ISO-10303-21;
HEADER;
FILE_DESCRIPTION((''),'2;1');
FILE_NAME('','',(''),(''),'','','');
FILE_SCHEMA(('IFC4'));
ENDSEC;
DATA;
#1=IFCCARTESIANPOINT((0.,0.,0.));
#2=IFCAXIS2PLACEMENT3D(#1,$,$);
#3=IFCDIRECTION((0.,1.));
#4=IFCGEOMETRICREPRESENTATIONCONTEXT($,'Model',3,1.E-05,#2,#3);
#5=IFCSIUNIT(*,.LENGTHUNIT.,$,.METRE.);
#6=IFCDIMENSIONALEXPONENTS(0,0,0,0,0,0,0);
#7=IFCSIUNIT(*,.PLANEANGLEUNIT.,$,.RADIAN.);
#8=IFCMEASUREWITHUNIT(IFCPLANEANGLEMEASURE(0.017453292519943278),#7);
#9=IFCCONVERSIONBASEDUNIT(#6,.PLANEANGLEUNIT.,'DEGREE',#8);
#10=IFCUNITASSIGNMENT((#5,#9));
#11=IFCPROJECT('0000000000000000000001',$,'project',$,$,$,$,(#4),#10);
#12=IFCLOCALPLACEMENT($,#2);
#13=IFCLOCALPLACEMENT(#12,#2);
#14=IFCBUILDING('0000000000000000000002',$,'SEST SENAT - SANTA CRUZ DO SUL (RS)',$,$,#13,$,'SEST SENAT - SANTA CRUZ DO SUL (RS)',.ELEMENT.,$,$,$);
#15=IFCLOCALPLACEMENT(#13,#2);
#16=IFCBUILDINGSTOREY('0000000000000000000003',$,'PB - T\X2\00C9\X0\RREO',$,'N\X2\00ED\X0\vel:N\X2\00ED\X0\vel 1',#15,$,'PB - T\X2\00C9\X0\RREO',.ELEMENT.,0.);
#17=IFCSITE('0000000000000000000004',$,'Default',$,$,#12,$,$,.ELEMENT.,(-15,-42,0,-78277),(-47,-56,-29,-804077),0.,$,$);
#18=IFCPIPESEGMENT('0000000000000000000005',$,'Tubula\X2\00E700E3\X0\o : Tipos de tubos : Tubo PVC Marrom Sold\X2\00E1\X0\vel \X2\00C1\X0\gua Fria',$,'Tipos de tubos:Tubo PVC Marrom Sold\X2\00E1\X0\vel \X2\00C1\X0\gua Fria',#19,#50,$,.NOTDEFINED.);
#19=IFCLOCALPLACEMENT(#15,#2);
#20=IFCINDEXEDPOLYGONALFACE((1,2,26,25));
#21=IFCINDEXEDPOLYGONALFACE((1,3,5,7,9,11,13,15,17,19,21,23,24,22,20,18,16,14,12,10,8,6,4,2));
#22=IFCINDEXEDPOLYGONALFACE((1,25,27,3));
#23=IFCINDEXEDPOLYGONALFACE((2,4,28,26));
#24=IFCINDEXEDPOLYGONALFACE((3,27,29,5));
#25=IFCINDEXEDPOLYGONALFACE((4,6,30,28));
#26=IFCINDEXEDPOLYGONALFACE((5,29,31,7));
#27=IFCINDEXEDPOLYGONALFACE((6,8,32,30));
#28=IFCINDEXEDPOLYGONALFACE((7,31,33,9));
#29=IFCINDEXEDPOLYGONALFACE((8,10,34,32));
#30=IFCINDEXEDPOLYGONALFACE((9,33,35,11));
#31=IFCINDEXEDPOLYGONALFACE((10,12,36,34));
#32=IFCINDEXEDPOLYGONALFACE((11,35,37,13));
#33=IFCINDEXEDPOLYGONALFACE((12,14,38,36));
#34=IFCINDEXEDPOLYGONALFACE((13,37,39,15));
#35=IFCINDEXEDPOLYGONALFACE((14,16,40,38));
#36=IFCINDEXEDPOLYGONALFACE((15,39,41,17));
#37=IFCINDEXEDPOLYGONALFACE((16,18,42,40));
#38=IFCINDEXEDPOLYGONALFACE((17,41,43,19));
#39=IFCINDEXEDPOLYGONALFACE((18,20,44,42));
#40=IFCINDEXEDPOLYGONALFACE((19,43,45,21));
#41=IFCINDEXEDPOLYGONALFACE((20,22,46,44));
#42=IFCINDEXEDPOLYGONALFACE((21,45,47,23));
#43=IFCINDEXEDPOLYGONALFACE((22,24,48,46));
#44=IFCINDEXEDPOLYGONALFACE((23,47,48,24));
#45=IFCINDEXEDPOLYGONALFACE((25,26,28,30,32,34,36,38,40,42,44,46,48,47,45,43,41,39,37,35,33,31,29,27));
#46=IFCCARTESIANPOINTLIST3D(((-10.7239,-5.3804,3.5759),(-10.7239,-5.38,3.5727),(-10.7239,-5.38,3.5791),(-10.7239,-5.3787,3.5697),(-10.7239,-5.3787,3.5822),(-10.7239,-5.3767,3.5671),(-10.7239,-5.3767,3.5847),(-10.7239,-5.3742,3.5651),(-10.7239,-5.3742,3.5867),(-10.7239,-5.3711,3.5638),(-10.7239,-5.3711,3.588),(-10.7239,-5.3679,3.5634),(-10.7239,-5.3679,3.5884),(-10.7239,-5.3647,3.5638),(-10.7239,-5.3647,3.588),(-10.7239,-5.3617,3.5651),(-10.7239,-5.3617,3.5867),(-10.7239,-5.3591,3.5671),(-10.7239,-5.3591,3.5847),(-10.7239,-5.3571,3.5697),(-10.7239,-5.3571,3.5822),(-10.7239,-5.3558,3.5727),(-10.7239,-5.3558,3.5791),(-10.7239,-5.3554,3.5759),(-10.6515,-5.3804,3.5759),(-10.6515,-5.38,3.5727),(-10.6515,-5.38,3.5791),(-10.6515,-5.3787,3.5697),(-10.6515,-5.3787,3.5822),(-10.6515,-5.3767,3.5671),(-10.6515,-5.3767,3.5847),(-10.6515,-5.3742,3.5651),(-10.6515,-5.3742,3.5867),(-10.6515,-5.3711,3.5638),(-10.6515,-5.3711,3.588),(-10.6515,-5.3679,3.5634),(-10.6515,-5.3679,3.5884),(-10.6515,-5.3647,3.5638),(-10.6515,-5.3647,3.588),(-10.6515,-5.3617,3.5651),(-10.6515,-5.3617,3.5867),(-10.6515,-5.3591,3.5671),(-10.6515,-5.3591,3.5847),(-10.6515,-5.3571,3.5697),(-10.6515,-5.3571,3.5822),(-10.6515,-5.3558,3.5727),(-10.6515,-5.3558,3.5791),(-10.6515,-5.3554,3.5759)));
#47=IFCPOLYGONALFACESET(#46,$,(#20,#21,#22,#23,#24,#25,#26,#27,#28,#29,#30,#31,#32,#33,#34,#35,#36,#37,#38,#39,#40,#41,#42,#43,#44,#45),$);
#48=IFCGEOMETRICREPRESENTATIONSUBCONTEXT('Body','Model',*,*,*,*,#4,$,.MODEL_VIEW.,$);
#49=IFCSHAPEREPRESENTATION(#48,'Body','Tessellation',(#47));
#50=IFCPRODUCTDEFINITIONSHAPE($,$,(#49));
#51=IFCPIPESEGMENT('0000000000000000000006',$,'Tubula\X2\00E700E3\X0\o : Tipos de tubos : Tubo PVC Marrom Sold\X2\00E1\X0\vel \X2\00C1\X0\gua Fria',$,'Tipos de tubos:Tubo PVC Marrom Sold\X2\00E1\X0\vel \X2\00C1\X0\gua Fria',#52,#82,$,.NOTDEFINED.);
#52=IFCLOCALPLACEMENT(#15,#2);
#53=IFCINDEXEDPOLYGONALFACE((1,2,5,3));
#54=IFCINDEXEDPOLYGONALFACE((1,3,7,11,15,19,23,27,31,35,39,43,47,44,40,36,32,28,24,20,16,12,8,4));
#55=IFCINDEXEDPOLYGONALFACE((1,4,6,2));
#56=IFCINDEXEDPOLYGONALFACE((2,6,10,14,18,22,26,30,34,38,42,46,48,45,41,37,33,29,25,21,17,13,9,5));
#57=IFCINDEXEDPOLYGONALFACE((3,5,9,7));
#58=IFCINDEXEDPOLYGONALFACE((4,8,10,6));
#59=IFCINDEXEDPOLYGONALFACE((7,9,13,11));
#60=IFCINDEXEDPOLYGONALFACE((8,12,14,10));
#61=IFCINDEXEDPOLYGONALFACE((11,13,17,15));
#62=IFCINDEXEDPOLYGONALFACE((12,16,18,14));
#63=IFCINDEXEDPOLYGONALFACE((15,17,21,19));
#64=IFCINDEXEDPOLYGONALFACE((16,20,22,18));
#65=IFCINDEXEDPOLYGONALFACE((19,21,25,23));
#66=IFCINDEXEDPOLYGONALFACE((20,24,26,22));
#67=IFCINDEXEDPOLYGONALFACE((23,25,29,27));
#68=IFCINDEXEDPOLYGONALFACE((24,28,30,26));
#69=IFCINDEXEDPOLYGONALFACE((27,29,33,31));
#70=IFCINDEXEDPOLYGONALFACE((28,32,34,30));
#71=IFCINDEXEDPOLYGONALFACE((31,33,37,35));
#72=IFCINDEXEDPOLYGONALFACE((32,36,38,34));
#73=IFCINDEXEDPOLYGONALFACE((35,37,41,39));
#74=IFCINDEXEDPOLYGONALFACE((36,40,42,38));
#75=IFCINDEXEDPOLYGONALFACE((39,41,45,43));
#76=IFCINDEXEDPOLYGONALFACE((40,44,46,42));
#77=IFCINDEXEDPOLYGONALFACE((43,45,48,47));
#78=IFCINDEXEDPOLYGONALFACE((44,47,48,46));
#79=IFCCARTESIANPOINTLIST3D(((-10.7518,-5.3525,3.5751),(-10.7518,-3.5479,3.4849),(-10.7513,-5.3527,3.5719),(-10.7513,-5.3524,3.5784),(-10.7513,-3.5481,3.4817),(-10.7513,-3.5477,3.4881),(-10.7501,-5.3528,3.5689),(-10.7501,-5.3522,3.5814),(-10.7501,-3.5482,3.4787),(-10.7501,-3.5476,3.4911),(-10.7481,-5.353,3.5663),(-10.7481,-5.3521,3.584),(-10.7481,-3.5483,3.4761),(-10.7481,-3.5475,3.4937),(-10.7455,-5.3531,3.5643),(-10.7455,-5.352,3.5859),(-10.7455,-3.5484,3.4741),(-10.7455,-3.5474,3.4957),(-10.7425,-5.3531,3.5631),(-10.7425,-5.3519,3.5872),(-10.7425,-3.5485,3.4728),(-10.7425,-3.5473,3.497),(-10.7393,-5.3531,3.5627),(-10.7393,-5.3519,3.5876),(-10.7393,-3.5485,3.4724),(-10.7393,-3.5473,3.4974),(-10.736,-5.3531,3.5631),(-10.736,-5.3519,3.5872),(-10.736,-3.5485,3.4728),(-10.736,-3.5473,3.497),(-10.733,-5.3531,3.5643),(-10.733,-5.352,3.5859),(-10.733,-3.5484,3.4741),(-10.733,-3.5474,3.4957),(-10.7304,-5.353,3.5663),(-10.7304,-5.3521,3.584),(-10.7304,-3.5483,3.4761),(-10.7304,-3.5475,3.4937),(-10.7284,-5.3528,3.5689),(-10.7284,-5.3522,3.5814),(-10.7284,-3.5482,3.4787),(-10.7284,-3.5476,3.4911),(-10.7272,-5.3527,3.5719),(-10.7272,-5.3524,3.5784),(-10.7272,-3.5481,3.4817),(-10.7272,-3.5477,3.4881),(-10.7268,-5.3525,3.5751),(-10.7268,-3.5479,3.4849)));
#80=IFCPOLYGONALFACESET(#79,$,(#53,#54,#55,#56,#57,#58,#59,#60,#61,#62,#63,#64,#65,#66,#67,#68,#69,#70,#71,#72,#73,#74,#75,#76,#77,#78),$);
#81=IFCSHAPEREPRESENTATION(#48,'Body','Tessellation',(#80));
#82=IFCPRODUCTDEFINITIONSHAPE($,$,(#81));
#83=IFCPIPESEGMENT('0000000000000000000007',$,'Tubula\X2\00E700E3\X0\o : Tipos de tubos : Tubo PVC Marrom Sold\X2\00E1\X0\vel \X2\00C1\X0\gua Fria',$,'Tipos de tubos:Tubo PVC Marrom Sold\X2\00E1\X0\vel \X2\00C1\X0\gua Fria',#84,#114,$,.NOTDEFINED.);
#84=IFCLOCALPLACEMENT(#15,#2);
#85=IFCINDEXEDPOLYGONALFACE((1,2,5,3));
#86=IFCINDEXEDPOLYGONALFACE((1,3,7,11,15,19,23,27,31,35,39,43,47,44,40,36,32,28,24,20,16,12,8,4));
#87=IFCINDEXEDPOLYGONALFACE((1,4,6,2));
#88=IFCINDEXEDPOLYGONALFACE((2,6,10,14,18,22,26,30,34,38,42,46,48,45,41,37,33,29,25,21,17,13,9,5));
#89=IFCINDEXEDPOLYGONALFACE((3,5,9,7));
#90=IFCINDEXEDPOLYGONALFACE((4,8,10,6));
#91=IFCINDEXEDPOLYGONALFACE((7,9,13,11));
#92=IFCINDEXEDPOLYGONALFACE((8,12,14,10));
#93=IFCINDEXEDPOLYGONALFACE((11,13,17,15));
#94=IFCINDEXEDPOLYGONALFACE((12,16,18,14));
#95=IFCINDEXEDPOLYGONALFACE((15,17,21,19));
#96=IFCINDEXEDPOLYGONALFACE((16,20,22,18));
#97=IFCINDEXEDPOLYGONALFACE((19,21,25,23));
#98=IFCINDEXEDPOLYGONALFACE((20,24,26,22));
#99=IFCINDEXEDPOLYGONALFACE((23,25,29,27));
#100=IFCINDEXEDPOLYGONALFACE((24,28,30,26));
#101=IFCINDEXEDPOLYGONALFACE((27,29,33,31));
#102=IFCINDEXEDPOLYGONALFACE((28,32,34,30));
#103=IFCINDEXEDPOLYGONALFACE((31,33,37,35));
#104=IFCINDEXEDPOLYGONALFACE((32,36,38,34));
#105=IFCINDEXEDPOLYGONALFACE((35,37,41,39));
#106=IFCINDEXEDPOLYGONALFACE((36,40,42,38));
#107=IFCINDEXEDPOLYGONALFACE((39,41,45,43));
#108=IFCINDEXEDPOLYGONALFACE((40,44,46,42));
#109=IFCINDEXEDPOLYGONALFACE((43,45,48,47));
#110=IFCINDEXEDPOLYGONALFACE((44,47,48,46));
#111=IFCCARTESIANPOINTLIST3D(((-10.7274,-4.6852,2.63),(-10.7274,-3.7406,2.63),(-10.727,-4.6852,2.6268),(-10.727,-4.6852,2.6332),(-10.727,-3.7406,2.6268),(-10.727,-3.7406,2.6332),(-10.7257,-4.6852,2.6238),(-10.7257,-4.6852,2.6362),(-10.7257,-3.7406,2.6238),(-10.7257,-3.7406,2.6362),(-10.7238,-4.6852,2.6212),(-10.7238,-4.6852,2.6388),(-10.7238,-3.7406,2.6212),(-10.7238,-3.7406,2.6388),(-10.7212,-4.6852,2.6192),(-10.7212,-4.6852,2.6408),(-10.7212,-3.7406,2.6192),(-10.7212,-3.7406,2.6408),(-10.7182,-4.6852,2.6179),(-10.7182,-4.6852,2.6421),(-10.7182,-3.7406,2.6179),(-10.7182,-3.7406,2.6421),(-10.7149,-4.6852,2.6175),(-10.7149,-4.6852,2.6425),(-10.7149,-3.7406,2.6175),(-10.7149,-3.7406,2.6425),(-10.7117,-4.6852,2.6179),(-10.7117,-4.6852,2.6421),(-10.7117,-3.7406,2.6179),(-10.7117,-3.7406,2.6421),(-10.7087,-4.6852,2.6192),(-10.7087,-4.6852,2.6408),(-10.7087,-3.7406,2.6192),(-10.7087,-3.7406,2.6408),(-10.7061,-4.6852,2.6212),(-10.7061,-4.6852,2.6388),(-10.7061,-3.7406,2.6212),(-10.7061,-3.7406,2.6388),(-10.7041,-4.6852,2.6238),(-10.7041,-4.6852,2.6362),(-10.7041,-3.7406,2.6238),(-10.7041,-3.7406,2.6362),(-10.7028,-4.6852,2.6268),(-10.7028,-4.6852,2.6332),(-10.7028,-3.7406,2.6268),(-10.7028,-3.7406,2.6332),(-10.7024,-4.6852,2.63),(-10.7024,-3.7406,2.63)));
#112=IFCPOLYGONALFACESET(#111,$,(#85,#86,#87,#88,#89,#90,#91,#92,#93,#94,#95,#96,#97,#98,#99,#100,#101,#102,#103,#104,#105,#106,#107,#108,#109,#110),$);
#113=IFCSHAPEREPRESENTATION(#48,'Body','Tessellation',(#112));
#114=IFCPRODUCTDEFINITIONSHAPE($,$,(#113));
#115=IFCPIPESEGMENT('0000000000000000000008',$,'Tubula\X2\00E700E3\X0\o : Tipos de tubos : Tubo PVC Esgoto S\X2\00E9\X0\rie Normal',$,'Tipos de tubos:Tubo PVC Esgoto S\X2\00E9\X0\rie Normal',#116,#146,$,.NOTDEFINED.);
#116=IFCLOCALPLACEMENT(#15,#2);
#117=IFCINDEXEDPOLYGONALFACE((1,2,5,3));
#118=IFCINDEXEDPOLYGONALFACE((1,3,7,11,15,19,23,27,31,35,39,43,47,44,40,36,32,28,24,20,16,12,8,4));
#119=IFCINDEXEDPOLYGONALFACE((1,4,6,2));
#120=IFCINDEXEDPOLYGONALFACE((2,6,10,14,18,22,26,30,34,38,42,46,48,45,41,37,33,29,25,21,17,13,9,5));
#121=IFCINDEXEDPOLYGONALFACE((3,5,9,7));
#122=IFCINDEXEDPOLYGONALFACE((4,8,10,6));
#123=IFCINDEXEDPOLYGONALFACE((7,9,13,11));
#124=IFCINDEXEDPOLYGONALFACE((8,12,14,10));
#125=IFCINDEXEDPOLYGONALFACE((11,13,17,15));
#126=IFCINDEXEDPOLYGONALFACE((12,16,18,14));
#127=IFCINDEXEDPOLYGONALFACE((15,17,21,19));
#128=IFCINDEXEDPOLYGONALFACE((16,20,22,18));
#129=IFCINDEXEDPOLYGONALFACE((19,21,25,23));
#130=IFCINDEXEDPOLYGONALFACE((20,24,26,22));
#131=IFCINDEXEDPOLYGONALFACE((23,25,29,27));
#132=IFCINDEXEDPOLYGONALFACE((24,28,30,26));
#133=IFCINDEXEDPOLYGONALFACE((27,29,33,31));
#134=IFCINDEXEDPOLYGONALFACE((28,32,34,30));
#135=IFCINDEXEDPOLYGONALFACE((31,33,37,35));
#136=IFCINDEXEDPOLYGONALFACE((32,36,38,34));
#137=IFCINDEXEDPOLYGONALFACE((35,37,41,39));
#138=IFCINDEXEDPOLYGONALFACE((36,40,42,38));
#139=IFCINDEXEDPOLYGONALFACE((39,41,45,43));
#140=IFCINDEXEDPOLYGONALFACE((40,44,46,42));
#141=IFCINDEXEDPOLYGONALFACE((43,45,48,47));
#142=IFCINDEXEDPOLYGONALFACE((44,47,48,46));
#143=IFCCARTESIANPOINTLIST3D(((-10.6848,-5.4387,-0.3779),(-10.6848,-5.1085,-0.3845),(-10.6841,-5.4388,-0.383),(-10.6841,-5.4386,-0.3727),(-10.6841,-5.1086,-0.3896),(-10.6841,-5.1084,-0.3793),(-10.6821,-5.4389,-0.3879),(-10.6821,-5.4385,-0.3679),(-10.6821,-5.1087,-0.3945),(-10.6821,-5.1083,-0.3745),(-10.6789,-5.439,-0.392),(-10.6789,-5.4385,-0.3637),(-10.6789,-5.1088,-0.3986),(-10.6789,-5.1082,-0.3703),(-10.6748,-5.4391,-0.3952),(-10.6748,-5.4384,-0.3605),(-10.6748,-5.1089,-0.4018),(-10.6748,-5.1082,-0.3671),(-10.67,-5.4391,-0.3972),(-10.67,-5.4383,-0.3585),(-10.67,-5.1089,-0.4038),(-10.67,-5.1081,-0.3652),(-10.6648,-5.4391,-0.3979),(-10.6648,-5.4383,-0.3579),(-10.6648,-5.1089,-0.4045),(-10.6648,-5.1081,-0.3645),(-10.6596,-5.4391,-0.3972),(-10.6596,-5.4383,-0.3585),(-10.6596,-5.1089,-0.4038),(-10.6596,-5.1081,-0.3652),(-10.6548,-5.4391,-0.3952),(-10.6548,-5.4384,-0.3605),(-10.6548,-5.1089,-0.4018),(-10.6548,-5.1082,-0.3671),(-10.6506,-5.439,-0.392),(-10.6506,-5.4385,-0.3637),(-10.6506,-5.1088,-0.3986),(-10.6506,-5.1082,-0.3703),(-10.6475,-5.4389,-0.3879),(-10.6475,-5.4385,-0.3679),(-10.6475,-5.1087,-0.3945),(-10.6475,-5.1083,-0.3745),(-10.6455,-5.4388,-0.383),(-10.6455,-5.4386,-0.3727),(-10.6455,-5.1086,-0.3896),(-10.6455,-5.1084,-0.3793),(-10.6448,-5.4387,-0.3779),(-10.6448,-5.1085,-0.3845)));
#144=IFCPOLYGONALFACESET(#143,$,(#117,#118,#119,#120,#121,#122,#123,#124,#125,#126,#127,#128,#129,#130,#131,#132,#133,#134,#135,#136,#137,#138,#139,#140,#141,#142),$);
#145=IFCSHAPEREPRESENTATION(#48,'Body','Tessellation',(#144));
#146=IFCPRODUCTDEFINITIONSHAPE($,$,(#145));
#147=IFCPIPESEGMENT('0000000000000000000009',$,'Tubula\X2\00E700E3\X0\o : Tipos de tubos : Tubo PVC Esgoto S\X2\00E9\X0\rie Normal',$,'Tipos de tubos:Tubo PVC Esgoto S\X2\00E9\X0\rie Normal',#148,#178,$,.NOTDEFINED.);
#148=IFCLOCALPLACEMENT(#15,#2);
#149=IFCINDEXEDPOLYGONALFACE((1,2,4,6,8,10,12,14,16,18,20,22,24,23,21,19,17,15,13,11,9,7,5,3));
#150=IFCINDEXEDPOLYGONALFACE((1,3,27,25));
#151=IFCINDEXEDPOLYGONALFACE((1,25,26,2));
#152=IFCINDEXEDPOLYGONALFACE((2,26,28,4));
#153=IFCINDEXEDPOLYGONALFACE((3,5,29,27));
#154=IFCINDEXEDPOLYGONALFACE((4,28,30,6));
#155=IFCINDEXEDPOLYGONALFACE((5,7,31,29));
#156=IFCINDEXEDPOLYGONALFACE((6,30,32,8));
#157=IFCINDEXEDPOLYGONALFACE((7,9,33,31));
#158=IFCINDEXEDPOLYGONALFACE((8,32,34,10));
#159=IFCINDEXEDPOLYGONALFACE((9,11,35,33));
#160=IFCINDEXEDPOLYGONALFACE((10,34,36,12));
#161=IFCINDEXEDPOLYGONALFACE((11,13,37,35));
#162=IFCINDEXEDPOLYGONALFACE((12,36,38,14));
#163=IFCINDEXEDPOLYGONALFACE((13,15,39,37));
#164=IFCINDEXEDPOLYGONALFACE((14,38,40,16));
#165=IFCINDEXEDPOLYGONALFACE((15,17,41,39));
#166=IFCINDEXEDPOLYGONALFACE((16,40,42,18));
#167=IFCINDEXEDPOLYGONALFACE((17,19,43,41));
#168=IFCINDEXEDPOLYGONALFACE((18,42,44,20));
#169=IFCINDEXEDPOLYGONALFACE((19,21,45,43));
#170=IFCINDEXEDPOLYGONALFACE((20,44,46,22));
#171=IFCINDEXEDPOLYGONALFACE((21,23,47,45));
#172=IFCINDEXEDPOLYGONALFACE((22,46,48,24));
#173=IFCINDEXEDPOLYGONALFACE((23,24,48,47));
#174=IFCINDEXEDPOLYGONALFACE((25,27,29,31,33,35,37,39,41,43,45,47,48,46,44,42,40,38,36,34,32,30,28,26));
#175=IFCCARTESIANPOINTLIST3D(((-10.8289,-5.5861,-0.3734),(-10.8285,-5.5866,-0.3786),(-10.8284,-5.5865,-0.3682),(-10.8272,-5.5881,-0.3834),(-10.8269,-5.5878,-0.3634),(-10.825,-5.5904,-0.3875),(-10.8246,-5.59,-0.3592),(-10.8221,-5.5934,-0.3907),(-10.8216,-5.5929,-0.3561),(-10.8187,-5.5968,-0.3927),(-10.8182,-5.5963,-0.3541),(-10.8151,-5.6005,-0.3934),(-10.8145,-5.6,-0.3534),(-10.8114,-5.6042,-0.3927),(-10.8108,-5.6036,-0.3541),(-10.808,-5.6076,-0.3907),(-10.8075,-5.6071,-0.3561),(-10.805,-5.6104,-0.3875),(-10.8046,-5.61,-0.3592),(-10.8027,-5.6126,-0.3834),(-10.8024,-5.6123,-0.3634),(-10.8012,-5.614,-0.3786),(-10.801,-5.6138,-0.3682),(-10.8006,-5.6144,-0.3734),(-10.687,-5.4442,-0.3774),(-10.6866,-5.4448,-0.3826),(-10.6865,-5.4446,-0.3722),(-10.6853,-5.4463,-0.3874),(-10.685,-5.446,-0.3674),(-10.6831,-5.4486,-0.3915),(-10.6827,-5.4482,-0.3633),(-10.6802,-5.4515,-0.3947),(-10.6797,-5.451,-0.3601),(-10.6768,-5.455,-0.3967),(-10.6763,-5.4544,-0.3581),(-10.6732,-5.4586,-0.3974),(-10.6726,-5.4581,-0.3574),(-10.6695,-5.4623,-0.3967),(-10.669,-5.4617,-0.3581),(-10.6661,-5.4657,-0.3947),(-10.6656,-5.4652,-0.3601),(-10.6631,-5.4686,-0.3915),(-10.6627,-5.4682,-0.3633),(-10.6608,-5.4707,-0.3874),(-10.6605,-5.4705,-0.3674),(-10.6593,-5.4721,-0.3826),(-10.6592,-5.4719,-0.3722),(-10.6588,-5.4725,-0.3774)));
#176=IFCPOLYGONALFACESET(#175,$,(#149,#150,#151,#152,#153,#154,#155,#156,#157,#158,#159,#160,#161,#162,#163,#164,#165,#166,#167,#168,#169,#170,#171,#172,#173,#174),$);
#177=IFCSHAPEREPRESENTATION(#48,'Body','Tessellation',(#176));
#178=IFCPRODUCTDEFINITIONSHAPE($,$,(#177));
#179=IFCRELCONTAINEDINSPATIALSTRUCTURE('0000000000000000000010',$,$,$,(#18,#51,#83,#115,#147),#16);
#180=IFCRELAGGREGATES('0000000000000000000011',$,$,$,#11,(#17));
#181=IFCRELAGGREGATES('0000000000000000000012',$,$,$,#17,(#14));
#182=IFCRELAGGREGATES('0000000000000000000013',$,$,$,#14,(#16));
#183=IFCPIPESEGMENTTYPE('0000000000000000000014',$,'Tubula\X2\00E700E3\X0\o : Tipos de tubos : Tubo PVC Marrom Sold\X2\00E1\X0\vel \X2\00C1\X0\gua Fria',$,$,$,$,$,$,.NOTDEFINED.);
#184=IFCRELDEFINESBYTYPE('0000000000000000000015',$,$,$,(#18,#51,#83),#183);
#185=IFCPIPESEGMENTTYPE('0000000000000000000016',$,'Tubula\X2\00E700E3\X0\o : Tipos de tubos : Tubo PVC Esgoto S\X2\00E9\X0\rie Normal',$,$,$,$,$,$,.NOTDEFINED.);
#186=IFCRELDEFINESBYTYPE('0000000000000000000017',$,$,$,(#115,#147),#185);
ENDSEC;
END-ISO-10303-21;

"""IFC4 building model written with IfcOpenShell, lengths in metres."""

from ifc_helpers import new_model, entity, si_unit, converted_unit, direction, frame, origin, place, context, subcontext, project, spatial, arc, indexed_curve, outline, extrude, type_object, element, save


model = new_model("IFC4")

# Units and contexts
model_context = context("Model", 3, precision=1e-05, world=origin(), true_north=direction((0.0, 1.0)))
body_context = subcontext(model_context, "Body", "Model", "MODEL_VIEW")
ifc_project = project(units=[si_unit("LENGTHUNIT", "METRE"), converted_unit("PLANEANGLEUNIT", "DEGREE", entity("IfcPlaneAngleMeasure", 0.017453292519943278), si_unit("PLANEANGLEUNIT", "RADIAN"), dimensions=[0, 0, 0, 0, 0, 0, 0])], contexts=[model_context])

# Site, building, storey
site_placement = place(None, origin())
site = spatial("IfcSite", under=ifc_project, at=site_placement, Name="Default", CompositionType="ELEMENT", RefLatitude=(-15, -42, 0, -78277), RefLongitude=(-47, -56, -29, -804077), RefElevation=0.0)
building_placement = place(site_placement, origin())
building = spatial("IfcBuilding", under=site, at=building_placement, Name="SEST SENAT - SANTA CRUZ DO SUL (RS)", LongName="SEST SENAT - SANTA CRUZ DO SUL (RS)", CompositionType="ELEMENT")
storey_placement = place(building_placement, origin())
storey = spatial("IfcBuildingStorey", under=building, at=storey_placement, Name="PB - TÉRREO", ObjectType="Nível:Nível 1", LongName="PB - TÉRREO", CompositionType="ELEMENT", Elevation=0.0)

# Pipe segments
pipe_segment_type_1 = type_object("IfcPipeSegmentType", Name="Tubulação : Tipos de tubos : Tubo PVC Marrom Soldável Água Fria", PredefinedType="NOTDEFINED")
pipe_segment_1_placement = place(storey_placement, frame((-10.7239, -5.382, 3.5618)))
element("IfcPipeSegment", 1, at=pipe_segment_1_placement, inside=storey, type_object=pipe_segment_type_1, Name="Tubulação : Tipos de tubos : Tubo PVC Marrom Soldável Água Fria", ObjectType="Tipos de tubos:Tubo PVC Marrom Soldável Água Fria", PredefinedType="NOTDEFINED", context=body_context, shape_type="SweptSolid", body=[
    extrude(outline(indexed_curve([(0.0125, 0.0), (0.0088, 0.0088), (0.0, 0.0125), (-0.0088, 0.0088), (-0.0125, 0.0), (-0.0088, -0.0088), (0.0, -0.0125), (0.0088, -0.0088)], segments=[arc(1, 2, 3), arc(3, 4, 5), arc(5, 6, 7), arc(7, 8, 1)], self_intersect=False)), frame((0.0, 0.0141, 0.0141), z_axis=(1.0, 0.0, 0.0), x_axis=(0.0, 1.0, 0.0)), (0.0, 0.0, 1.0), 0.0723),
])
pipe_segment_2_placement = place(storey_placement, frame((-10.7534, -5.3547, 3.5892)))
element("IfcPipeSegment", 2, at=pipe_segment_2_placement, inside=storey, type_object=pipe_segment_type_1, Name="Tubulação : Tipos de tubos : Tubo PVC Marrom Soldável Água Fria", ObjectType="Tipos de tubos:Tubo PVC Marrom Soldável Água Fria", PredefinedType="NOTDEFINED", context=body_context, shape_type="SweptSolid", body=[
    extrude(outline(indexed_curve([(0.0125, 0.0), (0.0088, 0.0088), (0.0, 0.0125), (-0.0088, 0.0088), (-0.0125, 0.0), (-0.0088, -0.0088), (0.0, -0.0125), (0.0088, -0.0088)], segments=[arc(1, 2, 3), arc(3, 4, 5), arc(5, 6, 7), arc(7, 8, 1)], self_intersect=False)), frame((0.0141, 0.0022, -0.0141), z_axis=(0.0, 0.998752, -0.049938), x_axis=(1.0, 0.0, 0.0)), (0.0, 0.0, 1.0), 1.8069),
])
pipe_segment_3_placement = place(storey_placement, frame((-10.729, -4.6852, 2.6159)))
element("IfcPipeSegment", 3, at=pipe_segment_3_placement, inside=storey, type_object=pipe_segment_type_1, Name="Tubulação : Tipos de tubos : Tubo PVC Marrom Soldável Água Fria", ObjectType="Tipos de tubos:Tubo PVC Marrom Soldável Água Fria", PredefinedType="NOTDEFINED", context=body_context, shape_type="SweptSolid", body=[
    extrude(outline(indexed_curve([(0.0125, 0.0), (0.0088, 0.0088), (0.0, 0.0125), (-0.0088, 0.0088), (-0.0125, 0.0), (-0.0088, -0.0088), (0.0, -0.0125), (0.0088, -0.0088)], segments=[arc(1, 2, 3), arc(3, 4, 5), arc(5, 6, 7), arc(7, 8, 1)], self_intersect=False)), frame((0.0141, 0.0, 0.0141), z_axis=(0.0, 1.0, 0.0), x_axis=(1.0, 0.0, 0.0)), (0.0, 0.0, 1.0), 0.9446),
])
pipe_segment_type_2 = type_object("IfcPipeSegmentType", Name="Tubulação : Tipos de tubos : Tubo PVC Esgoto Série Normal", PredefinedType="NOTDEFINED")
pipe_segment_4_placement = place(storey_placement, frame((-10.6864, -5.4407, -0.3563)))
element("IfcPipeSegment", 4, at=pipe_segment_4_placement, inside=storey, type_object=pipe_segment_type_2, Name="Tubulação : Tipos de tubos : Tubo PVC Esgoto Série Normal", ObjectType="Tipos de tubos:Tubo PVC Esgoto Série Normal", PredefinedType="NOTDEFINED", context=body_context, shape_type="SweptSolid", body=[
    extrude(outline(indexed_curve([(0.02, 0.0), (0.0141, 0.0141), (0.0, 0.02), (-0.0141, 0.0141), (-0.02, 0.0), (-0.0141, -0.0141), (0.0, -0.02), (0.0141, -0.0141)], segments=[arc(1, 2, 3), arc(3, 4, 5), arc(5, 6, 7), arc(7, 8, 1)], self_intersect=False)), frame((0.0216, 0.002, -0.0216), z_axis=(0.0, 0.9998, -0.019996), x_axis=(-1.0, 0.0, 0.0)), (0.0, 0.0, 1.0), 0.3303),
])
pipe_segment_5_placement = place(storey_placement, frame((-10.8305, -5.616, -0.3518)))
element("IfcPipeSegment", 5, at=pipe_segment_5_placement, inside=storey, type_object=pipe_segment_type_2, Name="Tubulação : Tipos de tubos : Tubo PVC Esgoto Série Normal", ObjectType="Tipos de tubos:Tubo PVC Esgoto Série Normal", PredefinedType="NOTDEFINED", context=body_context, shape_type="SweptSolid", body=[
    extrude(outline(indexed_curve([(0.02, 0.0), (0.0141, 0.0141), (0.0, 0.02), (-0.0141, 0.0141), (-0.02, 0.0), (-0.0141, -0.0141), (0.0, -0.02), (0.0141, -0.0141)], segments=[arc(1, 2, 3), arc(3, 4, 5), arc(5, 6, 7), arc(7, 8, 1)], self_intersect=False)), frame((0.0157, 0.0157, -0.0216), z_axis=(0.706965, 0.706965, -0.019996), x_axis=(-0.707107, 0.707107, 0.0)), (0.0, 0.0, 1.0), 0.2007),
])

save(model, "model.ifc")
